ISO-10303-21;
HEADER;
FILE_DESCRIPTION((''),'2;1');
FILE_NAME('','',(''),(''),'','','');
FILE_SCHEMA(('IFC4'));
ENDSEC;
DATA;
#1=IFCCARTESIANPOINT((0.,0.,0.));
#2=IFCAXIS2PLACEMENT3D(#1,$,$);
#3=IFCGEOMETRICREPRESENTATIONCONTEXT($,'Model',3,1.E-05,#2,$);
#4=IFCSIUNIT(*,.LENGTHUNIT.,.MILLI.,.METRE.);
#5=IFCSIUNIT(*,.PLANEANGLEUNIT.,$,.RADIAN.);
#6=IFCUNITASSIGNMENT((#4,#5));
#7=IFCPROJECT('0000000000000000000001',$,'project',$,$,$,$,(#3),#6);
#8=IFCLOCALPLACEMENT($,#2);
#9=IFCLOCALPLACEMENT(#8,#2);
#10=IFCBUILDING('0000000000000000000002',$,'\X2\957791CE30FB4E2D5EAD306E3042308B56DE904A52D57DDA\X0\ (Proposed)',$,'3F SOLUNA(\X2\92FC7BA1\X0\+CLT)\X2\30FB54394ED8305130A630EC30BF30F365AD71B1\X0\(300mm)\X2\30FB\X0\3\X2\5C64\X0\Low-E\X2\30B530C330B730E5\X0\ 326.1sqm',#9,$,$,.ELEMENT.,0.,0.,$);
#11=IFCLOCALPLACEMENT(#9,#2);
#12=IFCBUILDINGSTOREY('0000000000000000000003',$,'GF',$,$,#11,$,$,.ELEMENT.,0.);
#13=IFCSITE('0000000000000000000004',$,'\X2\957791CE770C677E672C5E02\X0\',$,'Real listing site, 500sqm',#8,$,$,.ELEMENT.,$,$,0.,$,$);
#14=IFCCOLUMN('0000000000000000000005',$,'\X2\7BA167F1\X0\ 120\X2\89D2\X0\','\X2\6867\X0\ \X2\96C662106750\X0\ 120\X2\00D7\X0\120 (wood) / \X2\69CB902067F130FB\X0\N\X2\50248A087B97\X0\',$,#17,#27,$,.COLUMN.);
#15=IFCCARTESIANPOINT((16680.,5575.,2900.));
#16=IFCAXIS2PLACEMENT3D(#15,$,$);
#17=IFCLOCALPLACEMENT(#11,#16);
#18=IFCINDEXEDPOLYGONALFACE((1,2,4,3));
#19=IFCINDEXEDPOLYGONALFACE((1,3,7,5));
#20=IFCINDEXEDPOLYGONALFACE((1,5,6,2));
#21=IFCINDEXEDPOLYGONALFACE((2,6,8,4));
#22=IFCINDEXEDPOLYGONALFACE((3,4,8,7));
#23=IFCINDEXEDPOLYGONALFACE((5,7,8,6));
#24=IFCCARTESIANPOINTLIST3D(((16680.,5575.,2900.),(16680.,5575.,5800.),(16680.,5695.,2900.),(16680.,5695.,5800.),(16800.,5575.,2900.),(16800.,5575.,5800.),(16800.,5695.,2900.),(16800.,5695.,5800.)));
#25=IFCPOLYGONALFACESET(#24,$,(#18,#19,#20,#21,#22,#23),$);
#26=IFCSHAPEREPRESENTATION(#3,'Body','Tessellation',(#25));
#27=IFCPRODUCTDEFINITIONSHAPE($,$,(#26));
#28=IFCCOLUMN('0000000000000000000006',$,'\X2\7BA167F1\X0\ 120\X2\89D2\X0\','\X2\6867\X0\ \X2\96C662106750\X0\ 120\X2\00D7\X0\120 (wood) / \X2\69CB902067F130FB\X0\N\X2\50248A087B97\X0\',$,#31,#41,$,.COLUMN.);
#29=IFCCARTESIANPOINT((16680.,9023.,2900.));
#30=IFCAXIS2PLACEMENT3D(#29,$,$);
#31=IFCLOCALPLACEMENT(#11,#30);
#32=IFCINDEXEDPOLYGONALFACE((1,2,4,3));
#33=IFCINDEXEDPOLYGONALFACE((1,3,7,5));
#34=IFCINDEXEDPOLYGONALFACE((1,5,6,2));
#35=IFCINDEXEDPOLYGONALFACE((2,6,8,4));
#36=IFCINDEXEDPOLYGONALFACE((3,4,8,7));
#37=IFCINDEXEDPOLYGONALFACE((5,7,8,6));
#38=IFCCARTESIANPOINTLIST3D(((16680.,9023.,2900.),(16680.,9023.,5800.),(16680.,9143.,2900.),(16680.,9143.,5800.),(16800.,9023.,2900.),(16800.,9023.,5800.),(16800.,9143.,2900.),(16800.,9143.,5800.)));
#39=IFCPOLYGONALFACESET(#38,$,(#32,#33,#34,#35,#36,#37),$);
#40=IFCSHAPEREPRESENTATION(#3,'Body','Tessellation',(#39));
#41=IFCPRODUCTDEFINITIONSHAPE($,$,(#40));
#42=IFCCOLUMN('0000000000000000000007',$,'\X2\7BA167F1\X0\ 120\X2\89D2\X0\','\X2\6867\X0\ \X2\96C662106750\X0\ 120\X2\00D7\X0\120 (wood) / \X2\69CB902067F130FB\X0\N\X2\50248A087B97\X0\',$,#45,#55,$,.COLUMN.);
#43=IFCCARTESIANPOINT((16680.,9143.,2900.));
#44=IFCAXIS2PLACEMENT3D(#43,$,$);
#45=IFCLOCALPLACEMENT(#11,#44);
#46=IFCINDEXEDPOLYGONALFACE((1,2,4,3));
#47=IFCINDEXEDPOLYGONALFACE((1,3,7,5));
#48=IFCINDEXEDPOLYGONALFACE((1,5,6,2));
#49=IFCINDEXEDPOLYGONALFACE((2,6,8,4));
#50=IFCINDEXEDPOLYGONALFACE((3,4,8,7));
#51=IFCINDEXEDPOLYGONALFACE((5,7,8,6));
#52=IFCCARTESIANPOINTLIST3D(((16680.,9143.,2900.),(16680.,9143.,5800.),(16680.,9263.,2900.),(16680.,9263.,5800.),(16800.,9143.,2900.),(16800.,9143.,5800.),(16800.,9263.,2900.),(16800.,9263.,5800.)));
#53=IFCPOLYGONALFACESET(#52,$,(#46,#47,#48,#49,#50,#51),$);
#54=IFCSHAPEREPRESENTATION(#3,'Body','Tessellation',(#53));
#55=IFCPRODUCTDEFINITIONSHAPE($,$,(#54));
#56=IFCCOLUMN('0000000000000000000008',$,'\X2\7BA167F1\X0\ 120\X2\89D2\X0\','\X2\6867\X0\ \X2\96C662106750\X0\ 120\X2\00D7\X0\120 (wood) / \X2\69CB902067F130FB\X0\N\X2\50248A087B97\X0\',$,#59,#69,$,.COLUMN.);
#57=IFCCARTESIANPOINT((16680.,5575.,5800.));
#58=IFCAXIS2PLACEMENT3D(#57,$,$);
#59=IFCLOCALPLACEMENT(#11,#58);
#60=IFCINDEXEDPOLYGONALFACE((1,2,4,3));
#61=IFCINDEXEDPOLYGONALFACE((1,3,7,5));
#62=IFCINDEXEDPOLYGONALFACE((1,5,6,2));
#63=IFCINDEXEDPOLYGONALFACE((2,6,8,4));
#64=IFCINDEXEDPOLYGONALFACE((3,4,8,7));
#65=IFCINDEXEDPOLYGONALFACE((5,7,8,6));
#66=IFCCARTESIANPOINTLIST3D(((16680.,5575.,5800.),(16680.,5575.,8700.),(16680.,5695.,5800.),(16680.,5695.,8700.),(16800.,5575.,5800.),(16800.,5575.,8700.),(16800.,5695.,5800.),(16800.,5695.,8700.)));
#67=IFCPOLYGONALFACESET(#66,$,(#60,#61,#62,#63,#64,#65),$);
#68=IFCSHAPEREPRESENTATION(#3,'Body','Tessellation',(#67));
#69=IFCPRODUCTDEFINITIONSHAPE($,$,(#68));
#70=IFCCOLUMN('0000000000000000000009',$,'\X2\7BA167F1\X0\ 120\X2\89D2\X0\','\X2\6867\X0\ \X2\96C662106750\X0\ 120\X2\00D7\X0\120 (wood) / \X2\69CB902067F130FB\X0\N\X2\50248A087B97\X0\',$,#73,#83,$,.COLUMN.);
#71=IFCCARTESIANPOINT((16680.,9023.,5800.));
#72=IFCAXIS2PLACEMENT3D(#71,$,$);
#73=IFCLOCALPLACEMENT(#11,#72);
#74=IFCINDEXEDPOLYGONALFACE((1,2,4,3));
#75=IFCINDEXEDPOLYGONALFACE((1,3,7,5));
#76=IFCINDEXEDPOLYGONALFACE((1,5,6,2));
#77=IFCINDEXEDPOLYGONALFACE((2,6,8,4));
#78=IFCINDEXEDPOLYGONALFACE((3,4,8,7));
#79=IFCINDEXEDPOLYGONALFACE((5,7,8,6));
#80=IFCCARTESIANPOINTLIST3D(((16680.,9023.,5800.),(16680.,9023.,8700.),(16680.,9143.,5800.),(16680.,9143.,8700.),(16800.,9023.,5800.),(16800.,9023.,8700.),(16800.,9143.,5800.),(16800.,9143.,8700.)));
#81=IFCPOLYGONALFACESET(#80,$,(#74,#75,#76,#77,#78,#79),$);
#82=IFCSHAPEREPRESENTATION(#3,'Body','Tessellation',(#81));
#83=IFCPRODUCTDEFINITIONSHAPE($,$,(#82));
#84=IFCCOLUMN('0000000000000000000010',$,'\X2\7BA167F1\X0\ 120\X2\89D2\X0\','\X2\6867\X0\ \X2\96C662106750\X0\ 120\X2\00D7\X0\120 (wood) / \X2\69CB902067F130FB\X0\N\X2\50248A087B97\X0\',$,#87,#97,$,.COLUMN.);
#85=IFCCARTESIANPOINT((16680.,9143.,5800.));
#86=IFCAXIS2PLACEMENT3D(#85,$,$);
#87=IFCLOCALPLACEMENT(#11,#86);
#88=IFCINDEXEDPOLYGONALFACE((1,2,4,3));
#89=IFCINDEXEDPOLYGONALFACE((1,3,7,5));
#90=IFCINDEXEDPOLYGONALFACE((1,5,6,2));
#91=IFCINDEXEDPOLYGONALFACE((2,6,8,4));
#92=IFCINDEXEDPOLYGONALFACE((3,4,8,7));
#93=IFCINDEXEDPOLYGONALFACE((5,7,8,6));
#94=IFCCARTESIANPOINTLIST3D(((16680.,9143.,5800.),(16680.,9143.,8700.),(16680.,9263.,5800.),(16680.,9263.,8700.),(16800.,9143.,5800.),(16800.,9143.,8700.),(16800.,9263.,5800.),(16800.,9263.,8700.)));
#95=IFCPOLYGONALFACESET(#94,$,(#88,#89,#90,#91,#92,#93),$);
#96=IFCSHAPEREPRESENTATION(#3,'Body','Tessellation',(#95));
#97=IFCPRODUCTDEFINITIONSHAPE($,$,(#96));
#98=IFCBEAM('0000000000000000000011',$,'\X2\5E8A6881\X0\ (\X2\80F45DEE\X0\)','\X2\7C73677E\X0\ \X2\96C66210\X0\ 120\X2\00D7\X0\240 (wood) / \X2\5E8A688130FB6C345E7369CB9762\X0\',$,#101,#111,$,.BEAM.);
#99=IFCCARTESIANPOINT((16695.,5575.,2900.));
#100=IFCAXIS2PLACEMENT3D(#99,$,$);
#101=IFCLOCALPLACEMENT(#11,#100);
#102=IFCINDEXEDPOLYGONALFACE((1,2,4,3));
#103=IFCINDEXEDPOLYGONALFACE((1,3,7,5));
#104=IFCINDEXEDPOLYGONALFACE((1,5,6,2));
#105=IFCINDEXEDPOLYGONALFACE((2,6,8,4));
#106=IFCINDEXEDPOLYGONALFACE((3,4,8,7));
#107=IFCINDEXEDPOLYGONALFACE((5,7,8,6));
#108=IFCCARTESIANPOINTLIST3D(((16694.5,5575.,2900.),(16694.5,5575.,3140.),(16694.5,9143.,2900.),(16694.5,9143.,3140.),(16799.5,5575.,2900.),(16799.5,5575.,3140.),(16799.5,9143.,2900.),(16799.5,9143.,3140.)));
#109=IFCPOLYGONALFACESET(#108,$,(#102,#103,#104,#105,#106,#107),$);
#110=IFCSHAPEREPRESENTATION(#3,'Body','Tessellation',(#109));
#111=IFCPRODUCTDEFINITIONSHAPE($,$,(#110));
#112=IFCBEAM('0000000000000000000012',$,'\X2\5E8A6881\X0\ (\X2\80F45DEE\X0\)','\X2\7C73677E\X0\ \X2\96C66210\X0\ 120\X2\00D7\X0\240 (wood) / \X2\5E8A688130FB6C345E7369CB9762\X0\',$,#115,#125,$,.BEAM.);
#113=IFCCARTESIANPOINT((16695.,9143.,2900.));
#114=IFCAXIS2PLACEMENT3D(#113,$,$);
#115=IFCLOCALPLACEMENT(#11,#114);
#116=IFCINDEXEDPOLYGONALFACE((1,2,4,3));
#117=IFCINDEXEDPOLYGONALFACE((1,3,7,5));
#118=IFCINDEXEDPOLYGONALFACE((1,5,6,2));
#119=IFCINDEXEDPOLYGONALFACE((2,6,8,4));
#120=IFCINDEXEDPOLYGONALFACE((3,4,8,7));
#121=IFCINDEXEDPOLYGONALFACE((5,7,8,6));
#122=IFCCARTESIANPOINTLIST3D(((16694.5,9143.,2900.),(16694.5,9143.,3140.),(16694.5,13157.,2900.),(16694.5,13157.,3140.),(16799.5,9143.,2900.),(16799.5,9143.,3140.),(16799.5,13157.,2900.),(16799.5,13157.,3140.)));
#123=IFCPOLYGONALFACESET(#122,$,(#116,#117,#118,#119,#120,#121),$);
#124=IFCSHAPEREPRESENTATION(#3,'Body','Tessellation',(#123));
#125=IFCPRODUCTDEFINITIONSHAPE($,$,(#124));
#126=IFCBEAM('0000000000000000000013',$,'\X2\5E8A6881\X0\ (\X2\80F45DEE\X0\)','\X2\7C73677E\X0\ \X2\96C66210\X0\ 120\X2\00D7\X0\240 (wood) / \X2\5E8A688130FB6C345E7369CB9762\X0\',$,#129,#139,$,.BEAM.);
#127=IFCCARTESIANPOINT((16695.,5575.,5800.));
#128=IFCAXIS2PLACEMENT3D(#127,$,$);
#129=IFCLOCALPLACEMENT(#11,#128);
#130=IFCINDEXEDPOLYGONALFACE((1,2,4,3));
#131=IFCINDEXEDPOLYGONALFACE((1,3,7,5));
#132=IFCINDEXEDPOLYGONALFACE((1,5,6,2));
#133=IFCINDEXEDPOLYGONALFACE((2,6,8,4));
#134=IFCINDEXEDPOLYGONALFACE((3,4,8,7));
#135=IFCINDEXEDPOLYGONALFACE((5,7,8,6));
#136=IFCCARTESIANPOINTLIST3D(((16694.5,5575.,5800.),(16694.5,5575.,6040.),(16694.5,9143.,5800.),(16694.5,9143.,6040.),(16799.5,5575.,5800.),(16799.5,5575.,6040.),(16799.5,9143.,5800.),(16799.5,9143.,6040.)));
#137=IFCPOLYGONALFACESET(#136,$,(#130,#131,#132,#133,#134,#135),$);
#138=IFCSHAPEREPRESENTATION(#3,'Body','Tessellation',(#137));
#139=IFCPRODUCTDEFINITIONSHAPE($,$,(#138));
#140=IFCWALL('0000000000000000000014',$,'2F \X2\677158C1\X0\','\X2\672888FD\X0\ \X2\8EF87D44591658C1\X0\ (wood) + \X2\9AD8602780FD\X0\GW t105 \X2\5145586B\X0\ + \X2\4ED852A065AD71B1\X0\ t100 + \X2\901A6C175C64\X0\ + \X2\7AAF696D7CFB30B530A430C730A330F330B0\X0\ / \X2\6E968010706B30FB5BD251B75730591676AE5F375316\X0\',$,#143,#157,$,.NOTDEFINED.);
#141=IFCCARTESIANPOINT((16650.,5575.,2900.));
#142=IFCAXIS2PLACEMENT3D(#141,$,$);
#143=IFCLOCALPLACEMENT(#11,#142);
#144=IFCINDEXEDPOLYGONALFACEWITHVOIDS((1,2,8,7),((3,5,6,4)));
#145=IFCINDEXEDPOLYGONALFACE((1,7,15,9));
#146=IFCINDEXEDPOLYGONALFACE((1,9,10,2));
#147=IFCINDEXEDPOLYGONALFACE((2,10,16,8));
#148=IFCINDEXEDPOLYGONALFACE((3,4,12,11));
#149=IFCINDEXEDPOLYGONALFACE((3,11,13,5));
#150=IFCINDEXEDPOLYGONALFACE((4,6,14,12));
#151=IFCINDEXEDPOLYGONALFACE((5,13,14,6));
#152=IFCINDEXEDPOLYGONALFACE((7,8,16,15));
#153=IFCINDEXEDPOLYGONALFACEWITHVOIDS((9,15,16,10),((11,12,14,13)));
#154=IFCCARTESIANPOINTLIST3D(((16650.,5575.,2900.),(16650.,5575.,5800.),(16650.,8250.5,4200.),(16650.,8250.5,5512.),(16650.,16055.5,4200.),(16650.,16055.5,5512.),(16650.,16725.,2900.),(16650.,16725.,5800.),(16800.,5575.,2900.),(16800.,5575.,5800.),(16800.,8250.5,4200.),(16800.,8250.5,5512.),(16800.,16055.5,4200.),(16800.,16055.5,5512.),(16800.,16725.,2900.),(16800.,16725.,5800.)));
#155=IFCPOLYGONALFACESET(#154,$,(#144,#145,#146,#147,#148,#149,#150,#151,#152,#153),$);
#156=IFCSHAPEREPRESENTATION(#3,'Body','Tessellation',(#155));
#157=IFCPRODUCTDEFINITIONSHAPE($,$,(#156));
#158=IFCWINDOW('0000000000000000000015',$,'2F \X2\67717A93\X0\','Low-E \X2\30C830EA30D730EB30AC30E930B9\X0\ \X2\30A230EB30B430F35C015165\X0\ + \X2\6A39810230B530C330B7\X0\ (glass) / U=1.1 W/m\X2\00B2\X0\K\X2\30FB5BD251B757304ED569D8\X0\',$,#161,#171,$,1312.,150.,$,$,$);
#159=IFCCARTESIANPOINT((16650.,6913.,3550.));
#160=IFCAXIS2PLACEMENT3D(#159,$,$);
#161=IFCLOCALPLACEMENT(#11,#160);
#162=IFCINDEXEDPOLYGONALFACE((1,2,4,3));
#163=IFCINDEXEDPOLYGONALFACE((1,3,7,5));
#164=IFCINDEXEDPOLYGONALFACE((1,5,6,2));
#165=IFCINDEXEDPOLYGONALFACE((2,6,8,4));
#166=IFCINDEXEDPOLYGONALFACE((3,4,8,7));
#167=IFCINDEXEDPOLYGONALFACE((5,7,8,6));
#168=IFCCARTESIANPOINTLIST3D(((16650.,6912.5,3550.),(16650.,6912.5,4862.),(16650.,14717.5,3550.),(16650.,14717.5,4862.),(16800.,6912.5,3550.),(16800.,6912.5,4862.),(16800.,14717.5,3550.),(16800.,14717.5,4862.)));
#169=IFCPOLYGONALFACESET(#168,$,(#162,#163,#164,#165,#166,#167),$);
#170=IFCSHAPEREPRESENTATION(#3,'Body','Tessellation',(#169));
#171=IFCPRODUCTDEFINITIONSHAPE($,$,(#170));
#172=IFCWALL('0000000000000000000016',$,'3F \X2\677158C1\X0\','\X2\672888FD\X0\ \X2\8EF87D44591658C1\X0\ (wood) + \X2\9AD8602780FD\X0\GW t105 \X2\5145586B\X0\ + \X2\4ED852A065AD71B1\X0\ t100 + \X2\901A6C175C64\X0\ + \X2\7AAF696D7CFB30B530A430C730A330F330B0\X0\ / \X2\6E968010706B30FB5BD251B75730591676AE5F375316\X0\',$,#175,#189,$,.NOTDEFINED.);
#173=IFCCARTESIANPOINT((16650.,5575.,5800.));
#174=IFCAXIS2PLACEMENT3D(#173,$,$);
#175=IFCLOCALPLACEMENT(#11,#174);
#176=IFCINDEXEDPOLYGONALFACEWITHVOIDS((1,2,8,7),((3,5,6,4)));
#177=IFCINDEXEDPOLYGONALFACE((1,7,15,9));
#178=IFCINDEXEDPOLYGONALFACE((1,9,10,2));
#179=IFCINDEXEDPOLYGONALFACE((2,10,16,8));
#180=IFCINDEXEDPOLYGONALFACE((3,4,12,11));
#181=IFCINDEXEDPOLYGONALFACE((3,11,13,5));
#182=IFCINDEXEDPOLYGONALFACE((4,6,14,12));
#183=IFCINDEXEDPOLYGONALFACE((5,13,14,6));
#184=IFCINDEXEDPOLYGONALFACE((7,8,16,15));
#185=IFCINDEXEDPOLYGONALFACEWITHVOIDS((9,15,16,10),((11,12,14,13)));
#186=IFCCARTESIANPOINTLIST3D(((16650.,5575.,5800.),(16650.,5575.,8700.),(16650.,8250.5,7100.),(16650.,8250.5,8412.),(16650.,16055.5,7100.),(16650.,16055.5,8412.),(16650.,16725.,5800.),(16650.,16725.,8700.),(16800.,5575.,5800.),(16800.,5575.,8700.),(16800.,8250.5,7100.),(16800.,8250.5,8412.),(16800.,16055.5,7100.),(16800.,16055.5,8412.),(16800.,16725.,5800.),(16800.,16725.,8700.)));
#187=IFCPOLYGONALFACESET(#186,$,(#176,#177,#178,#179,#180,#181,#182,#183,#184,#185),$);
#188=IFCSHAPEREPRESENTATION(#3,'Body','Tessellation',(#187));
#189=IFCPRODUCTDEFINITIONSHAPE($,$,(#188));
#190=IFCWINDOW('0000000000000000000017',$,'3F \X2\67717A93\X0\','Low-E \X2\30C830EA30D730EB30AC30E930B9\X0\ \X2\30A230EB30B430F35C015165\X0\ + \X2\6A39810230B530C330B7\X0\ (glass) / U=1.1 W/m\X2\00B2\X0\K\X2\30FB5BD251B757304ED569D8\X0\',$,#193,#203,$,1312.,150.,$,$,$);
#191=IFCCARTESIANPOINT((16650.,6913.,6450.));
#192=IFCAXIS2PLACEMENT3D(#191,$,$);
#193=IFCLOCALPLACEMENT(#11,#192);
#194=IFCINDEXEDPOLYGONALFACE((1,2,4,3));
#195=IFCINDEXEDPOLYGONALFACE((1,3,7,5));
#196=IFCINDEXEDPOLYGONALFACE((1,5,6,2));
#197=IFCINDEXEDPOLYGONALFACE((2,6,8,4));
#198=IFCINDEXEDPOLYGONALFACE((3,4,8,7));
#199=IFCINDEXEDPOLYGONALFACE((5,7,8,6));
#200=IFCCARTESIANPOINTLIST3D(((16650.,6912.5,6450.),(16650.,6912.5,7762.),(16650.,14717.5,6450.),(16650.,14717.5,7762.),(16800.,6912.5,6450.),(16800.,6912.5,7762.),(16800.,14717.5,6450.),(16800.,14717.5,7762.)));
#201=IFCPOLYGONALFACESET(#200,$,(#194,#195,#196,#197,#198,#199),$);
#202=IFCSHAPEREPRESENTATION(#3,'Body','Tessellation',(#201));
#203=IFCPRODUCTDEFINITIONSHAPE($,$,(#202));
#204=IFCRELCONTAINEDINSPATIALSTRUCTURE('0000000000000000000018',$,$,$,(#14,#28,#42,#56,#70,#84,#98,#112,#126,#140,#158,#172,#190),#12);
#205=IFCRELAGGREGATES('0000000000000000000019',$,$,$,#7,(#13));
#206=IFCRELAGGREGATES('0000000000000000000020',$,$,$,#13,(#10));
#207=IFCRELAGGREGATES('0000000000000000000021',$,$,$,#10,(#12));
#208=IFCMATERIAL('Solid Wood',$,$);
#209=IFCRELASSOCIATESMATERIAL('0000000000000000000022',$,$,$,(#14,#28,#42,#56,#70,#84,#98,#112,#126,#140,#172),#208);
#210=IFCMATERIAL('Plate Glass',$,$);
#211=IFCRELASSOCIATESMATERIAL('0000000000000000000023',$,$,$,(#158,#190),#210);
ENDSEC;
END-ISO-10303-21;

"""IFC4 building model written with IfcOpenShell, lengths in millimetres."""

from ifc_helpers import new_model, si_unit, frame, frame_2d, origin, place, context, project, spatial, rectangle, extrude, material, element, fill, save


model = new_model("IFC4")

# Units and contexts
model_context = context("Model", 3, precision=1e-05, world=origin())
ifc_project = project(units=[si_unit("LENGTHUNIT", "METRE", prefix="MILLI"), si_unit("PLANEANGLEUNIT", "RADIAN")], contexts=[model_context])

# Site, building, storey
site_placement = place(None, origin())
site = spatial("IfcSite", under=ifc_project, at=site_placement, Name="長野県松本市", ObjectType="Real listing site, 500sqm", CompositionType="ELEMENT", RefElevation=0.0)
building_placement = place(site_placement, origin())
building = spatial("IfcBuilding", under=site, at=building_placement, Name="長野・中庭のある回遊動線 (Proposed)", ObjectType="3F SOLUNA(鋼管+CLT)・吹付けウレタン断熱(300mm)・3層Low-Eサッシュ 326.1sqm", CompositionType="ELEMENT", ElevationOfRefHeight=0.0, ElevationOfTerrain=0.0)
storey_placement = place(building_placement, origin())
storey = spatial("IfcBuildingStorey", under=building, at=storey_placement, Name="GF", CompositionType="ELEMENT", Elevation=0.0)

# Columns
ifc_material_1 = material(Name="Solid Wood")
column_1_placement = place(storey_placement, frame((16680.0, 5575.0, 2900.0)))
element("IfcColumn", 1, at=column_1_placement, inside=storey, material=ifc_material_1, Name="管柱 120角", Description="桧 集成材 120×120 (wood) / 構造柱・N値計算", PredefinedType="COLUMN", context=model_context, shape_type="SweptSolid", body=[
    extrude(rectangle(XDim=120.0, YDim=120.0, at=frame_2d((60.0, 60.0))), frame((16680.0, 5575.0, 2900.0)), (0.0, 0.0, 1.0), 2900.0),
])
column_2_placement = place(storey_placement, frame((16680.0, 9023.0, 2900.0)))
element("IfcColumn", 2, at=column_2_placement, inside=storey, material=ifc_material_1, Name="管柱 120角", Description="桧 集成材 120×120 (wood) / 構造柱・N値計算", PredefinedType="COLUMN", context=model_context, shape_type="SweptSolid", body=[
    extrude(rectangle(XDim=120.0, YDim=120.0, at=frame_2d((60.0, 60.0))), frame((16680.0, 9023.0, 2900.0)), (0.0, 0.0, 1.0), 2900.0),
])
column_3_placement = place(storey_placement, frame((16680.0, 9143.0, 2900.0)))
element("IfcColumn", 3, at=column_3_placement, inside=storey, material=ifc_material_1, Name="管柱 120角", Description="桧 集成材 120×120 (wood) / 構造柱・N値計算", PredefinedType="COLUMN", context=model_context, shape_type="SweptSolid", body=[
    extrude(rectangle(XDim=120.0, YDim=120.0, at=frame_2d((60.0, 60.0))), frame((16680.0, 9143.0, 2900.0)), (0.0, 0.0, 1.0), 2900.0),
])
column_4_placement = place(storey_placement, frame((16680.0, 5575.0, 5800.0)))
element("IfcColumn", 4, at=column_4_placement, inside=storey, material=ifc_material_1, Name="管柱 120角", Description="桧 集成材 120×120 (wood) / 構造柱・N値計算", PredefinedType="COLUMN", context=model_context, shape_type="SweptSolid", body=[
    extrude(rectangle(XDim=120.0, YDim=120.0, at=frame_2d((60.0, 60.0))), frame((16680.0, 5575.0, 5800.0)), (0.0, 0.0, 1.0), 2900.0),
])
column_5_placement = place(storey_placement, frame((16680.0, 9023.0, 5800.0)))
element("IfcColumn", 5, at=column_5_placement, inside=storey, material=ifc_material_1, Name="管柱 120角", Description="桧 集成材 120×120 (wood) / 構造柱・N値計算", PredefinedType="COLUMN", context=model_context, shape_type="SweptSolid", body=[
    extrude(rectangle(XDim=120.0, YDim=120.0, at=frame_2d((60.0, 60.0))), frame((16680.0, 9023.0, 5800.0)), (0.0, 0.0, 1.0), 2900.0),
])
column_6_placement = place(storey_placement, frame((16680.0, 9143.0, 5800.0)))
element("IfcColumn", 6, at=column_6_placement, inside=storey, material=ifc_material_1, Name="管柱 120角", Description="桧 集成材 120×120 (wood) / 構造柱・N値計算", PredefinedType="COLUMN", context=model_context, shape_type="SweptSolid", body=[
    extrude(rectangle(XDim=120.0, YDim=120.0, at=frame_2d((60.0, 60.0))), frame((16680.0, 9143.0, 5800.0)), (0.0, 0.0, 1.0), 2900.0),
])

# Beams
beam_1_placement = place(storey_placement, frame((16695.0, 5575.0, 2900.0)))
element("IfcBeam", 7, at=beam_1_placement, inside=storey, material=ifc_material_1, Name="床梁 (胴差)", Description="米松 集成 120×240 (wood) / 床梁・水平構面", PredefinedType="BEAM", context=model_context, shape_type="SweptSolid", body=[
    extrude(rectangle(XDim=105.0, YDim=3568.0, at=frame_2d((52.0, 1784.0))), frame((16695.0, 5575.0, 2900.0)), (0.0, 0.0, 1.0), 240.0),
])
beam_2_placement = place(storey_placement, frame((16695.0, 9143.0, 2900.0)))
element("IfcBeam", 8, at=beam_2_placement, inside=storey, material=ifc_material_1, Name="床梁 (胴差)", Description="米松 集成 120×240 (wood) / 床梁・水平構面", PredefinedType="BEAM", context=model_context, shape_type="SweptSolid", body=[
    extrude(rectangle(XDim=105.0, YDim=4014.0, at=frame_2d((52.0, 2007.0))), frame((16695.0, 9143.0, 2900.0)), (0.0, 0.0, 1.0), 240.0),
])
beam_3_placement = place(storey_placement, frame((16695.0, 5575.0, 5800.0)))
element("IfcBeam", 9, at=beam_3_placement, inside=storey, material=ifc_material_1, Name="床梁 (胴差)", Description="米松 集成 120×240 (wood) / 床梁・水平構面", PredefinedType="BEAM", context=model_context, shape_type="SweptSolid", body=[
    extrude(rectangle(XDim=105.0, YDim=3568.0, at=frame_2d((52.0, 1784.0))), frame((16695.0, 5575.0, 5800.0)), (0.0, 0.0, 1.0), 240.0),
])

# Walls, openings, windows
wall_1_placement = place(storey_placement, frame((16650.0, 5575.0, 2900.0)))
wall_1 = element("IfcWall", 10, at=wall_1_placement, inside=storey, material=ifc_material_1, Name="2F 東壁", Description="木製 軸組外壁 (wood) + 高性能GW t105 充填 + 付加断熱 t100 + 通気層 + 窯業系サイディング / 準耐火・寒冷地外皮強化", PredefinedType="NOTDEFINED", context=model_context, shape_type="SweptSolid", body=[
    extrude(rectangle(XDim=150.0, YDim=11150.0, at=frame_2d((75.0, 5575.0))), frame((16650.0, 5575.0, 2900.0)), (0.0, 0.0, 1.0), 2900.0),
])
opening_1_placement = place(storey_placement, frame((16650.0, 6913.0, 3550.0)))
opening_1 = element("IfcOpeningElement", 11, at=opening_1_placement, cuts=wall_1, PredefinedType="NOTDEFINED", context=model_context, shape_type="SweptSolid", body=[
    extrude(rectangle(XDim=150.0, YDim=7805.0, at=frame_2d((75.0, 3902.0))), frame((16650.0, 6913.0, 3550.0)), (0.0, 0.0, 1.0), 1312.0),
])
ifc_material_2 = material(Name="Plate Glass")
window_1_placement = place(storey_placement, frame((16650.0, 6913.0, 3550.0)))
window_1 = element("IfcWindow", 12, at=window_1_placement, inside=storey, material=ifc_material_2, Name="2F 東窓", Description="Low-E トリプルガラス アルゴン封入 + 樹脂サッシ (glass) / U=1.1 W/m²K・寒冷地仕様", OverallHeight=1312.0, OverallWidth=150.0, context=model_context, shape_type="SweptSolid", body=[
    extrude(rectangle(XDim=150.0, YDim=7805.0, at=frame_2d((75.0, 3902.0))), frame((16650.0, 6913.0, 3550.0)), (0.0, 0.0, 1.0), 1312.0),
])
fill(opening_1, window_1)
wall_2_placement = place(storey_placement, frame((16650.0, 5575.0, 5800.0)))
wall_2 = element("IfcWall", 13, at=wall_2_placement, inside=storey, material=ifc_material_1, Name="3F 東壁", Description="木製 軸組外壁 (wood) + 高性能GW t105 充填 + 付加断熱 t100 + 通気層 + 窯業系サイディング / 準耐火・寒冷地外皮強化", PredefinedType="NOTDEFINED", context=model_context, shape_type="SweptSolid", body=[
    extrude(rectangle(XDim=150.0, YDim=11150.0, at=frame_2d((75.0, 5575.0))), frame((16650.0, 5575.0, 5800.0)), (0.0, 0.0, 1.0), 2900.0),
])
opening_2_placement = place(storey_placement, frame((16650.0, 6913.0, 6450.0)))
opening_2 = element("IfcOpeningElement", 14, at=opening_2_placement, cuts=wall_2, PredefinedType="NOTDEFINED", context=model_context, shape_type="SweptSolid", body=[
    extrude(rectangle(XDim=150.0, YDim=7805.0, at=frame_2d((75.0, 3902.0))), frame((16650.0, 6913.0, 6450.0)), (0.0, 0.0, 1.0), 1312.0),
])
window_2_placement = place(storey_placement, frame((16650.0, 6913.0, 6450.0)))
window_2 = element("IfcWindow", 15, at=window_2_placement, inside=storey, material=ifc_material_2, Name="3F 東窓", Description="Low-E トリプルガラス アルゴン封入 + 樹脂サッシ (glass) / U=1.1 W/m²K・寒冷地仕様", OverallHeight=1312.0, OverallWidth=150.0, context=model_context, shape_type="SweptSolid", body=[
    extrude(rectangle(XDim=150.0, YDim=7805.0, at=frame_2d((75.0, 3902.0))), frame((16650.0, 6913.0, 6450.0)), (0.0, 0.0, 1.0), 1312.0),
])
fill(opening_2, window_2)

save(model, "model.ifc")
